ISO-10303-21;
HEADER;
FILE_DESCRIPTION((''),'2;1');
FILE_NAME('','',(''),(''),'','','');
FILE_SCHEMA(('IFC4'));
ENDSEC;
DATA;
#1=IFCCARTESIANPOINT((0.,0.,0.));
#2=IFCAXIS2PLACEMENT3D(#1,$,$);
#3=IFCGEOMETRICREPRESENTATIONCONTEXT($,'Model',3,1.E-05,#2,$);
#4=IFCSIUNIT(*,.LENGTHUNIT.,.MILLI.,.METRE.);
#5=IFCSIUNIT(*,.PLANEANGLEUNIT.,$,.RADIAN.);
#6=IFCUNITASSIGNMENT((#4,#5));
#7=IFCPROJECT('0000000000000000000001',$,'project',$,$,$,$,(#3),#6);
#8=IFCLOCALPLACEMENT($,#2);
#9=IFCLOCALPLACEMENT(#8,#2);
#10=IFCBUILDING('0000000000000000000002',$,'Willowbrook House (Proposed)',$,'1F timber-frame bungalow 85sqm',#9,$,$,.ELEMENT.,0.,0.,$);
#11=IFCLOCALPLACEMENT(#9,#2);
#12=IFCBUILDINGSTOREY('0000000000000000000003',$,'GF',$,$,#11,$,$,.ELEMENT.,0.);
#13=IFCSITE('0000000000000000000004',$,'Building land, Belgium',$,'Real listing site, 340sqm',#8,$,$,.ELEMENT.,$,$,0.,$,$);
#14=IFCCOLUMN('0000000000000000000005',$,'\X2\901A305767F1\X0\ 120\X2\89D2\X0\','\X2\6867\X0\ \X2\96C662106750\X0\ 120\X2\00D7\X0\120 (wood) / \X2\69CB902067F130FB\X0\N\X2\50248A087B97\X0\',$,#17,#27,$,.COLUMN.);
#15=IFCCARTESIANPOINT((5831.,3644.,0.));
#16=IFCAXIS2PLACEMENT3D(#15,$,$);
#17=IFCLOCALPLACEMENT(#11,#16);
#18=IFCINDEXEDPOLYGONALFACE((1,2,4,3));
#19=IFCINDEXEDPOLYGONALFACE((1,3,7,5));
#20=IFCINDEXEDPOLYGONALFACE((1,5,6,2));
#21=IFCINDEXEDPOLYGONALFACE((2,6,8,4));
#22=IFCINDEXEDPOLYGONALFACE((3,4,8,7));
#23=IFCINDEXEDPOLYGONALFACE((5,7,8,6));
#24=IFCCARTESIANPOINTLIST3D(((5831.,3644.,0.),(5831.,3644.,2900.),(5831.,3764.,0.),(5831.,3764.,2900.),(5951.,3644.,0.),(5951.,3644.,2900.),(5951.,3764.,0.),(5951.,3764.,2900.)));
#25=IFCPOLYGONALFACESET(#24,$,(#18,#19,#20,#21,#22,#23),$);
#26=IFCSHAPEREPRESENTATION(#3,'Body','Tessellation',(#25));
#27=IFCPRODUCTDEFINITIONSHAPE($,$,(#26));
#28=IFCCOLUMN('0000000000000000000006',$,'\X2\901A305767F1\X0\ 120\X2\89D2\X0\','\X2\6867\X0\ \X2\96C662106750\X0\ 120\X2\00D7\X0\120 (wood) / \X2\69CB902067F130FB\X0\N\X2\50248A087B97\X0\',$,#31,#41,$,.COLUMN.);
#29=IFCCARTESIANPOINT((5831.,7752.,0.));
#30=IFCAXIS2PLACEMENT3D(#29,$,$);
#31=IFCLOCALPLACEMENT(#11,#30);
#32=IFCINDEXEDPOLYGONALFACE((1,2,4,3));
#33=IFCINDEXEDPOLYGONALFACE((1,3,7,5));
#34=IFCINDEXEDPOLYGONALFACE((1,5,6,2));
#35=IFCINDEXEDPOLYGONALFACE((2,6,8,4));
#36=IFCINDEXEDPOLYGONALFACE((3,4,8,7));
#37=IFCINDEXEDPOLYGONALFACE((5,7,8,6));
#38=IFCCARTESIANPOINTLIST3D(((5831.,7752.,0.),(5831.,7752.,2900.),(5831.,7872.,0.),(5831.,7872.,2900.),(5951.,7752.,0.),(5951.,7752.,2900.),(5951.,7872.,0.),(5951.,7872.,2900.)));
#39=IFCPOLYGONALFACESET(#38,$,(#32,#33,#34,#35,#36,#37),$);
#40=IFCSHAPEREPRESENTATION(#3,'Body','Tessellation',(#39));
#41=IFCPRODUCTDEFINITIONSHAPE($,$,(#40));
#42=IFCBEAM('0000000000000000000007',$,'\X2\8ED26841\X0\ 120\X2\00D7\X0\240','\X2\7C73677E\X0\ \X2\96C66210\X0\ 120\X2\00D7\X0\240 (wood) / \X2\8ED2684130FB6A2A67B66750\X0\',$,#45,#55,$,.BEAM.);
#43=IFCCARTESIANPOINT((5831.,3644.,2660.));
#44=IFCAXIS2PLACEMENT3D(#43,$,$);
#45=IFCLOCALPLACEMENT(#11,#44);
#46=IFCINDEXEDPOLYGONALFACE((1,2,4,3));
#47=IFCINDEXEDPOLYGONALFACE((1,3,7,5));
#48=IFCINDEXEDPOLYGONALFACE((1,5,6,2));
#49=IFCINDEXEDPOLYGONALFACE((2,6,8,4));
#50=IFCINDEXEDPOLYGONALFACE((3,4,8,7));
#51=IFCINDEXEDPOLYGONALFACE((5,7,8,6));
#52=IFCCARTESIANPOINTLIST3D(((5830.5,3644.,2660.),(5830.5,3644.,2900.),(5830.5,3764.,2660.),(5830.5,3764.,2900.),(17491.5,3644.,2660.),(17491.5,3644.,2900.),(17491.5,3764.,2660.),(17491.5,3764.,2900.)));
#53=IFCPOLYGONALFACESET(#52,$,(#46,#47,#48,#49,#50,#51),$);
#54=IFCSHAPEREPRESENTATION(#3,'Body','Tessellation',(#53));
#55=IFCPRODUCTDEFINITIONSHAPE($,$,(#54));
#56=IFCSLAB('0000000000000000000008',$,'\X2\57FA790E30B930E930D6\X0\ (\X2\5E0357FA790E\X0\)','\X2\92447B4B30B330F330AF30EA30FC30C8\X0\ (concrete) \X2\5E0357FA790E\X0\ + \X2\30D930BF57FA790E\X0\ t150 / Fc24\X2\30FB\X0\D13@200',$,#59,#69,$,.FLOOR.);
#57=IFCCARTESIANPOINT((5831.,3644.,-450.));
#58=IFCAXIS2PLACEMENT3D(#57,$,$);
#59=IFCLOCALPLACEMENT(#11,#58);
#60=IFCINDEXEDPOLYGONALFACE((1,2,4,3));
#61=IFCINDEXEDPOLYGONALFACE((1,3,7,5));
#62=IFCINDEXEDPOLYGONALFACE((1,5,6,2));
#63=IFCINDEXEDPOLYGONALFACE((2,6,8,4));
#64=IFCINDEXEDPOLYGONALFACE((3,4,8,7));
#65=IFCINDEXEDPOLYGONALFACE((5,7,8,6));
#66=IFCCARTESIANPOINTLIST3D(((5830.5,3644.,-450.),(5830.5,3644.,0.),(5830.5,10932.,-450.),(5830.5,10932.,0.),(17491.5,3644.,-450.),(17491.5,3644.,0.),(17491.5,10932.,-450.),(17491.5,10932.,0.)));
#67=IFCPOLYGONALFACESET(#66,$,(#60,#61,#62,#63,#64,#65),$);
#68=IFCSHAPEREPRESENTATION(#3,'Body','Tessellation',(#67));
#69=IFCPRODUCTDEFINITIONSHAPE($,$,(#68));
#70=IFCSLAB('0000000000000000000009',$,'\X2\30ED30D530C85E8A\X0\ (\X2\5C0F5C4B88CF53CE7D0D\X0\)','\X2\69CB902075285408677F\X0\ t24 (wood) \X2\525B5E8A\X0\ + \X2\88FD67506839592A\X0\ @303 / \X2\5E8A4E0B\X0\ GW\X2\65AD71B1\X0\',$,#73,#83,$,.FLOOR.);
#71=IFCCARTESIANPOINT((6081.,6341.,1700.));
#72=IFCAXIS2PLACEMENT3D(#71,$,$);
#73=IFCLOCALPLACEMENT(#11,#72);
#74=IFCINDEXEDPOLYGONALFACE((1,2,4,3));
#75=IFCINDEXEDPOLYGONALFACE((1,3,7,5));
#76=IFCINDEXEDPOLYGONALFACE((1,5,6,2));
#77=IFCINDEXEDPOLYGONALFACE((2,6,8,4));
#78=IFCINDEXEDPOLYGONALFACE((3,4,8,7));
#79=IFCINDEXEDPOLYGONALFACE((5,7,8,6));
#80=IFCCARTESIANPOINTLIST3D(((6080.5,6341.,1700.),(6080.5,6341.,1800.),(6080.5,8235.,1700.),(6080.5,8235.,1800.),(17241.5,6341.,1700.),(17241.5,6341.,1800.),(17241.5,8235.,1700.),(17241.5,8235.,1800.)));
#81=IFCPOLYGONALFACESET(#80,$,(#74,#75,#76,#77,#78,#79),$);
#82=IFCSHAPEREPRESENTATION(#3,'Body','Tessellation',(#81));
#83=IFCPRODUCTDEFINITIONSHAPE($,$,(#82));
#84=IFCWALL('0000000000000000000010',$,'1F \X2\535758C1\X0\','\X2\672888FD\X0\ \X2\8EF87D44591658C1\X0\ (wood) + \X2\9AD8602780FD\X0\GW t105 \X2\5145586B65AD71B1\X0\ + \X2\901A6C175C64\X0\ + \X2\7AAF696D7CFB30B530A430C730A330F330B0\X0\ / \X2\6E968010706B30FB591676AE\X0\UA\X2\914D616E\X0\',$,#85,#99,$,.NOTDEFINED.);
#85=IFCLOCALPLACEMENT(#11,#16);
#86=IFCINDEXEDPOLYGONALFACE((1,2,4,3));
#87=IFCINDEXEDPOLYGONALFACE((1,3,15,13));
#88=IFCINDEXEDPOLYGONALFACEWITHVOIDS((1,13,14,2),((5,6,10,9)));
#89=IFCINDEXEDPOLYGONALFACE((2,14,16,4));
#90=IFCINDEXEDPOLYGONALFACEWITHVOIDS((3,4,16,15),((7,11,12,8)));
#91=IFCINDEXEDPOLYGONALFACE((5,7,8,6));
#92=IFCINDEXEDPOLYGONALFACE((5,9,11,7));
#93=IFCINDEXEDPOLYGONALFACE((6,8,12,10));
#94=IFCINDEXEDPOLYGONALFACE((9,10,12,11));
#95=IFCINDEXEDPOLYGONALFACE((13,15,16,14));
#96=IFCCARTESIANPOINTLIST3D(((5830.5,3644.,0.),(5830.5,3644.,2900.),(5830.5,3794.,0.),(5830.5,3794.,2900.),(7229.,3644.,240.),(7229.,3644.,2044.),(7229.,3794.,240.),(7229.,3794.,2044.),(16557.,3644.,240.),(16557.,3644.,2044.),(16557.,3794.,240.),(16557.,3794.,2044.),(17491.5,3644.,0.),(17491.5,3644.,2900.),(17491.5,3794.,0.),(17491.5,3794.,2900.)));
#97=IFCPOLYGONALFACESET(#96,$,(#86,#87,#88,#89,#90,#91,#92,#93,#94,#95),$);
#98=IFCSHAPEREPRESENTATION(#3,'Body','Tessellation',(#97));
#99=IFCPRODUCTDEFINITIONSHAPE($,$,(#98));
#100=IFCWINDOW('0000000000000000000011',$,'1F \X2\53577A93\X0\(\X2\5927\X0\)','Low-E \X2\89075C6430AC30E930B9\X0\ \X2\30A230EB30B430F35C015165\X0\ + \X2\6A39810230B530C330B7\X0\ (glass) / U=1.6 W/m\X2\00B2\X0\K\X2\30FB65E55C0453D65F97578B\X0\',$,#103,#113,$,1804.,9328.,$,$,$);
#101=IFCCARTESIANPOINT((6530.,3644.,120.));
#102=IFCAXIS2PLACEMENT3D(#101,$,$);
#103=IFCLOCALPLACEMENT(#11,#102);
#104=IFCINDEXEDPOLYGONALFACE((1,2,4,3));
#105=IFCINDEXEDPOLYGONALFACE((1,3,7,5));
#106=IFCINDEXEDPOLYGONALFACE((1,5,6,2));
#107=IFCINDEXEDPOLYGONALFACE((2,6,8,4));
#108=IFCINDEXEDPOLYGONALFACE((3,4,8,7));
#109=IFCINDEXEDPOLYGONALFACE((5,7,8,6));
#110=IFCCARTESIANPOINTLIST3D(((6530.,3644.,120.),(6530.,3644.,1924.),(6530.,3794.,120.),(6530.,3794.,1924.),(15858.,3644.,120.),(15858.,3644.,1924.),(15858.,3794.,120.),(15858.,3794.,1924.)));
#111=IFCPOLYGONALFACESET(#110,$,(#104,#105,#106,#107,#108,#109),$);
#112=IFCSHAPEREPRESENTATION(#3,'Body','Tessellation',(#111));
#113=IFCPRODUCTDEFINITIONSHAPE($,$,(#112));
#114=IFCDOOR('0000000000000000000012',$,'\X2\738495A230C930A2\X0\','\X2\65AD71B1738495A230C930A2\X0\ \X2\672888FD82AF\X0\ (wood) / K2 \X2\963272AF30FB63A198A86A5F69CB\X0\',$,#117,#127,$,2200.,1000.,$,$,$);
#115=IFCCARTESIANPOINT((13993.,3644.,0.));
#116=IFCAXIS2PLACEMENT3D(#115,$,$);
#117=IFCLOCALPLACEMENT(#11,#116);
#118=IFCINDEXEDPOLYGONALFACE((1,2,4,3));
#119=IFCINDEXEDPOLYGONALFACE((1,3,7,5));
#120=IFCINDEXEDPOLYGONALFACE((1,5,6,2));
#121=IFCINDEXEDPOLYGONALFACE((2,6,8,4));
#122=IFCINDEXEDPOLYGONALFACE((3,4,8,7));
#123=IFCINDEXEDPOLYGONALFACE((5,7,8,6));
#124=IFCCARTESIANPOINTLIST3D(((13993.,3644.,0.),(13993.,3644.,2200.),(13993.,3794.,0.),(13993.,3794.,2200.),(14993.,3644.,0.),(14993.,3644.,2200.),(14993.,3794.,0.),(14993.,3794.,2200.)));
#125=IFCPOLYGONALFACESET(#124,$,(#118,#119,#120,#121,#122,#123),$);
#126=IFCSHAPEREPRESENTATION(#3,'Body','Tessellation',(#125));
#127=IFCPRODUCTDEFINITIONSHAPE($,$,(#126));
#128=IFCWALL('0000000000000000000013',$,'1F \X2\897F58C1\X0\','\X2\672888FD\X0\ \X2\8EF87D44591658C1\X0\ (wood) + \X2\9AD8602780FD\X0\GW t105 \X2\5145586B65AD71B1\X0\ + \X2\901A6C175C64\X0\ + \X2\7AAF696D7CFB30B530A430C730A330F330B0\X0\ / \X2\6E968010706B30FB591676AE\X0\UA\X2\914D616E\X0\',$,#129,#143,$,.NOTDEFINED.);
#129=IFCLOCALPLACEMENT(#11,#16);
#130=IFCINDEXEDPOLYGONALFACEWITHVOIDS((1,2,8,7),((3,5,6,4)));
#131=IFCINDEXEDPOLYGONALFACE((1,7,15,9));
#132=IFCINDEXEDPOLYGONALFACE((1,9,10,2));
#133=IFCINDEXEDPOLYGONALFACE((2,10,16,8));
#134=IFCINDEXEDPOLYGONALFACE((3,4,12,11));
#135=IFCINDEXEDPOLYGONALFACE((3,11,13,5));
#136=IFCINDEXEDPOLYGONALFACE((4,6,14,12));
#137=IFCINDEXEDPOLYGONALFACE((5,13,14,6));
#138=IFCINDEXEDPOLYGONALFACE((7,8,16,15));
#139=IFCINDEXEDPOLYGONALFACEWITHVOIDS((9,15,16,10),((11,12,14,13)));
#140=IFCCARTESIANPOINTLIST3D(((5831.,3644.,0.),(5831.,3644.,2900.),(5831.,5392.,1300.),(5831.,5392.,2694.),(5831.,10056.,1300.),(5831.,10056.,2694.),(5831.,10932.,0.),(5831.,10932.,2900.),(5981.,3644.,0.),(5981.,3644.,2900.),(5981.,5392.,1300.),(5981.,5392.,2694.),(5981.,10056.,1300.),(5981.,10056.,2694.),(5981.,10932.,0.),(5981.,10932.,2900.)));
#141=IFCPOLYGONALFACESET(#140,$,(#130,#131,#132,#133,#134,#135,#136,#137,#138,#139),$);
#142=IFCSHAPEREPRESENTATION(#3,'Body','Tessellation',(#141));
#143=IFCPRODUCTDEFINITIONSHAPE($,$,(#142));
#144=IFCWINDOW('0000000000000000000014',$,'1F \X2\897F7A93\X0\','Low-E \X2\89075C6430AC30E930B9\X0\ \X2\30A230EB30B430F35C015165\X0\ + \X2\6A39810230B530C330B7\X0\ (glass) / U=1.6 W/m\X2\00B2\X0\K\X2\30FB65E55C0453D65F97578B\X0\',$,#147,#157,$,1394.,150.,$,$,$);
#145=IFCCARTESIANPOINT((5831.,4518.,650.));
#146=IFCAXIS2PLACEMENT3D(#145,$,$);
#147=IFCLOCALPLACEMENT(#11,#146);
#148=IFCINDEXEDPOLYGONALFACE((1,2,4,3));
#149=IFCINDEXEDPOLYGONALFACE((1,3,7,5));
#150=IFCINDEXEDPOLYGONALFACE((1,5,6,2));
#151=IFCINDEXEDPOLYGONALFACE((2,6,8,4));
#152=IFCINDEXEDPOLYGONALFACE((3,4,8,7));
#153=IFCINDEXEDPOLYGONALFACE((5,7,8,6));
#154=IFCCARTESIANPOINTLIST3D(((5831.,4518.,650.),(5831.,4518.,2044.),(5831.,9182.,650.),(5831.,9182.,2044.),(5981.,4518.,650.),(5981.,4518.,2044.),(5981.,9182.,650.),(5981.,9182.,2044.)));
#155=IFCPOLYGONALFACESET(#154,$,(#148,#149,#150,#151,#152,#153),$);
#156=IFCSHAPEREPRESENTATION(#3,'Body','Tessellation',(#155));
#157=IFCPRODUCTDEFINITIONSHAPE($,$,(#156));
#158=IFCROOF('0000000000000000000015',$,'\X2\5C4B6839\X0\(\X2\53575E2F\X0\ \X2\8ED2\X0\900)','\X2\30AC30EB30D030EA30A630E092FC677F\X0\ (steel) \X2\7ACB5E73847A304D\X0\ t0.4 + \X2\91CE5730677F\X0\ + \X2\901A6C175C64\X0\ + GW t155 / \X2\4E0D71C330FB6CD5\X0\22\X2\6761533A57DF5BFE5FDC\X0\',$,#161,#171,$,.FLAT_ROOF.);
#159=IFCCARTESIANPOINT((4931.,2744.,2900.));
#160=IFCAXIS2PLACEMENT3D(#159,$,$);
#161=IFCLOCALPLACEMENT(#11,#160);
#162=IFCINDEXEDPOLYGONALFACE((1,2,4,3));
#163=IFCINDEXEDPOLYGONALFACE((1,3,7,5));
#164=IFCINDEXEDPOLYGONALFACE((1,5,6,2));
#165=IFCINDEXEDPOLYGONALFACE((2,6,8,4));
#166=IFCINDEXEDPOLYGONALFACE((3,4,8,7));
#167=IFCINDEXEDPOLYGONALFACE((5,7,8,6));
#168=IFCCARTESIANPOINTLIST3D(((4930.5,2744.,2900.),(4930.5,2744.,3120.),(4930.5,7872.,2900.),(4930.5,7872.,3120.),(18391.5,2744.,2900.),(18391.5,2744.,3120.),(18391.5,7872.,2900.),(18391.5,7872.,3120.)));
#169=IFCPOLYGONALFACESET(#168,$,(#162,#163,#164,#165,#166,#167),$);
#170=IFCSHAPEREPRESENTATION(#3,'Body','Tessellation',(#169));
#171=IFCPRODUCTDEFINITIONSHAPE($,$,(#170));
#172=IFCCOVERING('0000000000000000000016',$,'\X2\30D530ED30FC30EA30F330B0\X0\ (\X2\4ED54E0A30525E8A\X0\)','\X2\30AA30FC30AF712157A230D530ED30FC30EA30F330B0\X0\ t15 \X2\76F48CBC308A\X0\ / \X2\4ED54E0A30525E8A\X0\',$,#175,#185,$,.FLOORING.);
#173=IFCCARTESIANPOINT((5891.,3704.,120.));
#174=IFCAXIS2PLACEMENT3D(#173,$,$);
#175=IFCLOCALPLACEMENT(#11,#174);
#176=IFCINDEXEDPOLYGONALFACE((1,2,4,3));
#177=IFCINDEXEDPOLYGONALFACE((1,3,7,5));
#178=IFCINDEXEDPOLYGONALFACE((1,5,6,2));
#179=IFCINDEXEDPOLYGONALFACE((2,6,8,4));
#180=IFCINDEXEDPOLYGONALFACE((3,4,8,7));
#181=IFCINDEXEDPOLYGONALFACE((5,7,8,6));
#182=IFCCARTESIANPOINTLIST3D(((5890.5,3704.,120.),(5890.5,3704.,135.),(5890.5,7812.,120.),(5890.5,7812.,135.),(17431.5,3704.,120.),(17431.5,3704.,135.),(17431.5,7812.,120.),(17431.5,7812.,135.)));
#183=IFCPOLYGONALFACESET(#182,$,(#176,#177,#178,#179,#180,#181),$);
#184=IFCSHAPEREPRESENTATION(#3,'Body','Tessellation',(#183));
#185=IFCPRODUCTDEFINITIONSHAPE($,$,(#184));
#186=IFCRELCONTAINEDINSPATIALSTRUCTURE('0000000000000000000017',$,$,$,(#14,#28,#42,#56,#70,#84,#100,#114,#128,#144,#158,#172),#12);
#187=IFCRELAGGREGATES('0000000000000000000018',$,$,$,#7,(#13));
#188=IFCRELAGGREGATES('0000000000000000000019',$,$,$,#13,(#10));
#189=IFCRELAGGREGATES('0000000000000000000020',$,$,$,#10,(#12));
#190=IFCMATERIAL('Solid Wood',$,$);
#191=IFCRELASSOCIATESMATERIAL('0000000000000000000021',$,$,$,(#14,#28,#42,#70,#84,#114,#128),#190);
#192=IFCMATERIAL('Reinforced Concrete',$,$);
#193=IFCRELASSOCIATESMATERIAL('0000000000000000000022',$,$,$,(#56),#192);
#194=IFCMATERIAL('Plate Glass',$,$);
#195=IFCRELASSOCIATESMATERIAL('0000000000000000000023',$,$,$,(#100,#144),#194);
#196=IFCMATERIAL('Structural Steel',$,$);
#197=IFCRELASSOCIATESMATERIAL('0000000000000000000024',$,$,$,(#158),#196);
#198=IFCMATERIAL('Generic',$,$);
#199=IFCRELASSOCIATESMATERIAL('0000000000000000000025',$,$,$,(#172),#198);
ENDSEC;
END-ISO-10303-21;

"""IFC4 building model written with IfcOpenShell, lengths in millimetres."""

from ifc_helpers import new_model, si_unit, frame, frame_2d, origin, place, context, project, spatial, rectangle, extrude, material, element, fill, save


model = new_model("IFC4")

# Units and contexts
model_context = context("Model", 3, precision=1e-05, world=origin())
ifc_project = project(units=[si_unit("LENGTHUNIT", "METRE", prefix="MILLI"), si_unit("PLANEANGLEUNIT", "RADIAN")], contexts=[model_context])

# Site, building, storey
site_placement = place(None, origin())
site = spatial("IfcSite", under=ifc_project, at=site_placement, Name="Building land, Belgium", ObjectType="Real listing site, 340sqm", CompositionType="ELEMENT", RefElevation=0.0)
building_placement = place(site_placement, origin())
building = spatial("IfcBuilding", under=site, at=building_placement, Name="Willowbrook House (Proposed)", ObjectType="1F timber-frame bungalow 85sqm", CompositionType="ELEMENT", ElevationOfRefHeight=0.0, ElevationOfTerrain=0.0)
storey_placement = place(building_placement, origin())
storey = spatial("IfcBuildingStorey", under=building, at=storey_placement, Name="GF", CompositionType="ELEMENT", Elevation=0.0)

# Columns
ifc_material_1 = material(Name="Solid Wood")
column_1_placement = place(storey_placement, frame((5831.0, 3644.0, 0.0)))
element("IfcColumn", 1, at=column_1_placement, inside=storey, material=ifc_material_1, Name="通し柱 120角", Description="桧 集成材 120×120 (wood) / 構造柱・N値計算", PredefinedType="COLUMN", context=model_context, shape_type="SweptSolid", body=[
    extrude(rectangle(XDim=120.0, YDim=120.0, at=frame_2d((60.0, 60.0))), frame((5831.0, 3644.0, 0.0)), (0.0, 0.0, 1.0), 2900.0),
])
column_2_placement = place(storey_placement, frame((5831.0, 7752.0, 0.0)))
element("IfcColumn", 2, at=column_2_placement, inside=storey, material=ifc_material_1, Name="通し柱 120角", Description="桧 集成材 120×120 (wood) / 構造柱・N値計算", PredefinedType="COLUMN", context=model_context, shape_type="SweptSolid", body=[
    extrude(rectangle(XDim=120.0, YDim=120.0, at=frame_2d((60.0, 60.0))), frame((5831.0, 7752.0, 0.0)), (0.0, 0.0, 1.0), 2900.0),
])

# Beam
beam_1_placement = place(storey_placement, frame((5831.0, 3644.0, 2660.0)))
element("IfcBeam", 3, at=beam_1_placement, inside=storey, material=ifc_material_1, Name="軒桁 120×240", Description="米松 集成 120×240 (wood) / 軒桁・横架材", PredefinedType="BEAM", context=model_context, shape_type="SweptSolid", body=[
    extrude(rectangle(XDim=11661.0, YDim=120.0, at=frame_2d((5830.0, 60.0))), frame((5831.0, 3644.0, 2660.0)), (0.0, 0.0, 1.0), 240.0),
])

# Slabs
ifc_material_2 = material(Name="Reinforced Concrete")
slab_1_placement = place(storey_placement, frame((5831.0, 3644.0, -450.0)))
element("IfcSlab", 4, at=slab_1_placement, inside=storey, material=ifc_material_2, Name="基礎スラブ (布基礎)", Description="鉄筋コンクリート (concrete) 布基礎 + ベタ基礎 t150 / Fc24・D13@200", PredefinedType="FLOOR", context=model_context, shape_type="SweptSolid", body=[
    extrude(rectangle(XDim=11661.0, YDim=7288.0, at=frame_2d((5830.0, 3644.0))), frame((5831.0, 3644.0, -450.0)), (0.0, 0.0, 1.0), 450.0),
])
slab_2_placement = place(storey_placement, frame((6081.0, 6341.0, 1700.0)))
element("IfcSlab", 5, at=slab_2_placement, inside=storey, material=ifc_material_1, Name="ロフト床 (小屋裏収納)", Description="構造用合板 t24 (wood) 剛床 + 製材根太 @303 / 床下 GW断熱", PredefinedType="FLOOR", context=model_context, shape_type="SweptSolid", body=[
    extrude(rectangle(XDim=11161.0, YDim=1894.0, at=frame_2d((5580.0, 947.0))), frame((6081.0, 6341.0, 1700.0)), (0.0, 0.0, 1.0), 100.0),
])

# Wall, openings, window, door
wall_1_placement = place(storey_placement, frame((5831.0, 3644.0, 0.0)))
wall_1 = element("IfcWall", 6, at=wall_1_placement, inside=storey, material=ifc_material_1, Name="1F 南壁", Description="木製 軸組外壁 (wood) + 高性能GW t105 充填断熱 + 通気層 + 窯業系サイディング / 準耐火・外皮UA配慮", PredefinedType="NOTDEFINED", context=model_context, shape_type="SweptSolid", body=[
    extrude(rectangle(XDim=11661.0, YDim=150.0, at=frame_2d((5830.0, 75.0))), frame((5831.0, 3644.0, 0.0)), (0.0, 0.0, 1.0), 2900.0),
])
opening_1_placement = place(storey_placement, frame((6530.0, 3644.0, 120.0)))
opening_1 = element("IfcOpeningElement", 7, at=opening_1_placement, cuts=wall_1, PredefinedType="NOTDEFINED", context=model_context, shape_type="SweptSolid", body=[
    extrude(rectangle(XDim=9328.0, YDim=150.0, at=frame_2d((4664.0, 75.0))), frame((6530.0, 3644.0, 120.0)), (0.0, 0.0, 1.0), 1804.0),
])
opening_2_placement = place(storey_placement, frame((13993.0, 3644.0, 0.0)))
opening_2 = element("IfcOpeningElement", 8, at=opening_2_placement, cuts=wall_1, PredefinedType="NOTDEFINED", context=model_context, shape_type="SweptSolid", body=[
    extrude(rectangle(XDim=1000.0, YDim=150.0, at=frame_2d((500.0, 75.0))), frame((13993.0, 3644.0, 0.0)), (0.0, 0.0, 1.0), 2200.0),
])
ifc_material_3 = material(Name="Plate Glass")
window_1_placement = place(storey_placement, frame((6530.0, 3644.0, 120.0)))
window_1 = element("IfcWindow", 9, at=window_1_placement, inside=storey, material=ifc_material_3, Name="1F 南窓(大)", Description="Low-E 複層ガラス アルゴン封入 + 樹脂サッシ (glass) / U=1.6 W/m²K・日射取得型", OverallHeight=1804.0, OverallWidth=9328.0, context=model_context, shape_type="SweptSolid", body=[
    extrude(rectangle(XDim=9328.0, YDim=150.0, at=frame_2d((4664.0, 75.0))), frame((6530.0, 3644.0, 120.0)), (0.0, 0.0, 1.0), 1804.0),
])
fill(opening_1, window_1)
door_placement = place(storey_placement, frame((13993.0, 3644.0, 0.0)))
door = element("IfcDoor", 10, at=door_placement, inside=storey, material=ifc_material_1, Name="玄関ドア", Description="断熱玄関ドア 木製芯 (wood) / K2 防犯・採風機構", OverallHeight=2200.0, OverallWidth=1000.0, context=model_context, shape_type="SweptSolid", body=[
    extrude(rectangle(XDim=1000.0, YDim=150.0, at=frame_2d((500.0, 75.0))), frame((13993.0, 3644.0, 0.0)), (0.0, 0.0, 1.0), 2200.0),
])
fill(opening_2, door)

# Wall, opening, window
wall_2_placement = place(storey_placement, frame((5831.0, 3644.0, 0.0)))
wall_2 = element("IfcWall", 11, at=wall_2_placement, inside=storey, material=ifc_material_1, Name="1F 西壁", Description="木製 軸組外壁 (wood) + 高性能GW t105 充填断熱 + 通気層 + 窯業系サイディング / 準耐火・外皮UA配慮", PredefinedType="NOTDEFINED", context=model_context, shape_type="SweptSolid", body=[
    extrude(rectangle(XDim=150.0, YDim=7288.0, at=frame_2d((75.0, 3644.0))), frame((5831.0, 3644.0, 0.0)), (0.0, 0.0, 1.0), 2900.0),
])
opening_3_placement = place(storey_placement, frame((5831.0, 4518.0, 650.0)))
opening_3 = element("IfcOpeningElement", 12, at=opening_3_placement, cuts=wall_2, PredefinedType="NOTDEFINED", context=model_context, shape_type="SweptSolid", body=[
    extrude(rectangle(XDim=150.0, YDim=4664.0, at=frame_2d((75.0, 2332.0))), frame((5831.0, 4518.0, 650.0)), (0.0, 0.0, 1.0), 1394.0),
])
window_2_placement = place(storey_placement, frame((5831.0, 4518.0, 650.0)))
window_2 = element("IfcWindow", 13, at=window_2_placement, inside=storey, material=ifc_material_3, Name="1F 西窓", Description="Low-E 複層ガラス アルゴン封入 + 樹脂サッシ (glass) / U=1.6 W/m²K・日射取得型", OverallHeight=1394.0, OverallWidth=150.0, context=model_context, shape_type="SweptSolid", body=[
    extrude(rectangle(XDim=150.0, YDim=4664.0, at=frame_2d((75.0, 2332.0))), frame((5831.0, 4518.0, 650.0)), (0.0, 0.0, 1.0), 1394.0),
])
fill(opening_3, window_2)

# Roof
ifc_material_4 = material(Name="Structural Steel")
roof_placement = place(storey_placement, frame((4931.0, 2744.0, 2900.0)))
element("IfcRoof", 14, at=roof_placement, inside=storey, material=ifc_material_4, Name="屋根(南帯 軒900)", Description="ガルバリウム鋼板 (steel) 立平葺き t0.4 + 野地板 + 通気層 + GW t155 / 不燃・法22条区域対応", PredefinedType="FLAT_ROOF", context=model_context, shape_type="SweptSolid", body=[
    extrude(rectangle(XDim=13461.0, YDim=5128.0, at=frame_2d((6730.0, 2564.0))), frame((4931.0, 2744.0, 2900.0)), (0.0, 0.0, 1.0), 220.0),
])

# Covering
ifc_material_5 = material(Name="Generic")
covering_1_placement = place(storey_placement, frame((5891.0, 3704.0, 120.0)))
element("IfcCovering", 15, at=covering_1_placement, inside=storey, material=ifc_material_5, Name="フローリング (仕上げ床)", Description="オーク無垢フローリング t15 直貼り / 仕上げ床", PredefinedType="FLOORING", context=model_context, shape_type="SweptSolid", body=[
    extrude(rectangle(XDim=11541.0, YDim=4108.0, at=frame_2d((5770.0, 2054.0))), frame((5891.0, 3704.0, 120.0)), (0.0, 0.0, 1.0), 15.0),
])

save(model, "model.ifc")
